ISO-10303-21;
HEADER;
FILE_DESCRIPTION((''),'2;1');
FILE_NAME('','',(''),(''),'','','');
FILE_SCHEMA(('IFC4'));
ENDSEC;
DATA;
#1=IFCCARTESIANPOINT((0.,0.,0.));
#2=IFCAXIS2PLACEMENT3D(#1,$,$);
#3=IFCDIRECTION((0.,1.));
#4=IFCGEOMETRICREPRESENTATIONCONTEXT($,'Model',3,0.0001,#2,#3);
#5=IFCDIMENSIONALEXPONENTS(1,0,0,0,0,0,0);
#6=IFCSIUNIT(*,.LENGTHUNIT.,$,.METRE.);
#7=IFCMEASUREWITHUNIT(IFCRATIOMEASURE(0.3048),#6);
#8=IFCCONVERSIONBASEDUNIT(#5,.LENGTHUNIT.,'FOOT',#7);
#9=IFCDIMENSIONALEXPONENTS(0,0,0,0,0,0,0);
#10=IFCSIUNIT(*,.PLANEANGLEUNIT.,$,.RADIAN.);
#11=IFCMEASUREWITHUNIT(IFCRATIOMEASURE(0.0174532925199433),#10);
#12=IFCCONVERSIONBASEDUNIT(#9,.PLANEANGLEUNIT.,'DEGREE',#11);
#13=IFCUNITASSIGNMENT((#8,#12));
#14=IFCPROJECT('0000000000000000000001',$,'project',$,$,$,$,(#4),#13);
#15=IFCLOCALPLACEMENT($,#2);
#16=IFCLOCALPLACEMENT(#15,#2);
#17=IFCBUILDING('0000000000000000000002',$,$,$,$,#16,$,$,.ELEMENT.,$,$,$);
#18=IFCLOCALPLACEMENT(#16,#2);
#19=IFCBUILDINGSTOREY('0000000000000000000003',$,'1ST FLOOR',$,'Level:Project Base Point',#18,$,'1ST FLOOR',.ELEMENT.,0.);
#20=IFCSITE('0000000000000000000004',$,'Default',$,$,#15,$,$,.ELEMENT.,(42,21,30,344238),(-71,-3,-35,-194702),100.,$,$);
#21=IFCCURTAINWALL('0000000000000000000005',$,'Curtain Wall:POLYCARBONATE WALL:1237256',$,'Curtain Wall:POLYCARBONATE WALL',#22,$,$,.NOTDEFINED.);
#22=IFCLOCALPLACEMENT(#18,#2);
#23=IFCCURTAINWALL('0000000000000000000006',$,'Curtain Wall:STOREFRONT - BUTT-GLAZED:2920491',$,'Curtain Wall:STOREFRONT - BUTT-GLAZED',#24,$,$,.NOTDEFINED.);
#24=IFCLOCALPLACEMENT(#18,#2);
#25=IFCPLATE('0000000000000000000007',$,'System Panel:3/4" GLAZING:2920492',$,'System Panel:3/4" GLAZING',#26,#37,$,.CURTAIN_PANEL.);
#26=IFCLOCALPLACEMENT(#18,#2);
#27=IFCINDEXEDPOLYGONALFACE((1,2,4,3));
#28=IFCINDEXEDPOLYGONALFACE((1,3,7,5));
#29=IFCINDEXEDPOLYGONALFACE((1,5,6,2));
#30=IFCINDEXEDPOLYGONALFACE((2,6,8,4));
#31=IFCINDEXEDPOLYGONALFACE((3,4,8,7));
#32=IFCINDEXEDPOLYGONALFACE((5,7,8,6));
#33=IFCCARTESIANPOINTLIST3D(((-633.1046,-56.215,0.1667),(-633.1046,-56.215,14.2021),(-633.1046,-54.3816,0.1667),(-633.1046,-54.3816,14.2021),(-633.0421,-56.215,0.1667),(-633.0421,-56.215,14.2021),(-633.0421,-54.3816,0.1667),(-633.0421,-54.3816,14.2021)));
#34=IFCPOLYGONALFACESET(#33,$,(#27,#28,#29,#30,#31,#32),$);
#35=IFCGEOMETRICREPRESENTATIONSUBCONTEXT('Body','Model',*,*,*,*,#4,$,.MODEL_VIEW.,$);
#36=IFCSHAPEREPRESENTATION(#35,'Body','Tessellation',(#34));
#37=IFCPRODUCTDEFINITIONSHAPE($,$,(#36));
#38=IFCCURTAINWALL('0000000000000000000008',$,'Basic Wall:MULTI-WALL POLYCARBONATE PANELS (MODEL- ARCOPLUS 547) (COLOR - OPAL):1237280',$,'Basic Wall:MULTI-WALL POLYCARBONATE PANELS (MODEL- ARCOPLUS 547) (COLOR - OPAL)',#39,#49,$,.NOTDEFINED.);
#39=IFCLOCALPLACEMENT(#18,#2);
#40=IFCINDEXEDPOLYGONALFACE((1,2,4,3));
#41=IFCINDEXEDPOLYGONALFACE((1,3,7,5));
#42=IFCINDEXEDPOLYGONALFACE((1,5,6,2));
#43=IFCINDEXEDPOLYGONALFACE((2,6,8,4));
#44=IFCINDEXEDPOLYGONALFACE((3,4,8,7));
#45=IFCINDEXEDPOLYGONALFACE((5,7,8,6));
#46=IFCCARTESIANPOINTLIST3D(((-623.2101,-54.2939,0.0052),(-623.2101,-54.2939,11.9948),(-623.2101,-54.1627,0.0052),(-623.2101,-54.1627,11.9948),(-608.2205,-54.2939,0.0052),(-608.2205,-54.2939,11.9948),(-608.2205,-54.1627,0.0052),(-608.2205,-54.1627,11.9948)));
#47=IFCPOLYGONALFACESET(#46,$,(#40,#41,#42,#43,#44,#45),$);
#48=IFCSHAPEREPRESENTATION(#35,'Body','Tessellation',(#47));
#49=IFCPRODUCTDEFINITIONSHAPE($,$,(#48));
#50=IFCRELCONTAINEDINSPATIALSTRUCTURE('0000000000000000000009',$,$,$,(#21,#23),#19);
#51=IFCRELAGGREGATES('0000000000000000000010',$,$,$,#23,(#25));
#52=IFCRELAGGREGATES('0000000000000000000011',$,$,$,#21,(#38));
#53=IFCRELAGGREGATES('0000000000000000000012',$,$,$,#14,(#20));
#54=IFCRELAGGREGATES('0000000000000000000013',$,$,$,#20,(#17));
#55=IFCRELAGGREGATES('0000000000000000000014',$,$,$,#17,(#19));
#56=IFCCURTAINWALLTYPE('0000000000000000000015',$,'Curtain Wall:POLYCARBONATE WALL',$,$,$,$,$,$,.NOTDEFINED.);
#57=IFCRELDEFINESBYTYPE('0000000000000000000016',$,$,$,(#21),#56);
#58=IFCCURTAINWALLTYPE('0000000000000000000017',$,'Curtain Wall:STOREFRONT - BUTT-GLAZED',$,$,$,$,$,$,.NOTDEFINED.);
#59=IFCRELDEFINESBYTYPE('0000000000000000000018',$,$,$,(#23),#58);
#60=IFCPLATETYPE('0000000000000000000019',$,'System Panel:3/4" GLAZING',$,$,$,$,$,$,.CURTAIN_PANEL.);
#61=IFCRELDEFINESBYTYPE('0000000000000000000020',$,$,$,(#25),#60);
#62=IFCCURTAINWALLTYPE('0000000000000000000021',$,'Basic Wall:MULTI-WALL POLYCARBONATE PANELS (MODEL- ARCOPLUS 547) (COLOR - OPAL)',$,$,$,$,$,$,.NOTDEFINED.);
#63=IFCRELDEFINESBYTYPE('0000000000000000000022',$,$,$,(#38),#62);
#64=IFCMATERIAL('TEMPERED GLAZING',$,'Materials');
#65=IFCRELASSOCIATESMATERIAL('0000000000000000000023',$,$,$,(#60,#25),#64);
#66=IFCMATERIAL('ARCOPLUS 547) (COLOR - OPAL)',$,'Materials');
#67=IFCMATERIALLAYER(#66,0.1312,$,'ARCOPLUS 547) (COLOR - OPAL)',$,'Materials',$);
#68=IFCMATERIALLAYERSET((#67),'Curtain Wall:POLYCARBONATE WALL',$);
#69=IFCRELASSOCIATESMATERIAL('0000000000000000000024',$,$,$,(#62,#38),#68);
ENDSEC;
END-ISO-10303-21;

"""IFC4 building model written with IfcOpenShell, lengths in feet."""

from ifc_helpers import new_model, entity, si_unit, converted_unit, direction, frame, frame_2d, origin, origin_2d_with_axis, place, context, subcontext, project, spatial, rectangle, extrude, source, transform, mapped, material, layer, layer_set, layer_usage, type_object, type_shapes, element, aggregate, save


model = new_model("IFC4")

# Units and contexts
model_context = context("Model", 3, precision=0.0001, world=origin(), true_north=direction((0.0, 1.0)))
body_context = subcontext(model_context, "Body", "Model", "MODEL_VIEW")
ifc_project = project(units=[converted_unit("LENGTHUNIT", "FOOT", entity("IfcRatioMeasure", 0.3048), si_unit("LENGTHUNIT", "METRE"), dimensions=[1, 0, 0, 0, 0, 0, 0]), converted_unit("PLANEANGLEUNIT", "DEGREE", entity("IfcRatioMeasure", 0.0174532925199433), si_unit("PLANEANGLEUNIT", "RADIAN"), dimensions=[0, 0, 0, 0, 0, 0, 0])], contexts=[model_context])

# Site, building, storey
site_placement = place(None, origin())
site = spatial("IfcSite", under=ifc_project, at=site_placement, Name="Default", CompositionType="ELEMENT", RefLatitude=(42, 21, 30, 344238), RefLongitude=(-71, -3, -35, -194702), RefElevation=100.0)
building_placement = place(site_placement, origin())
building = spatial("IfcBuilding", under=site, at=building_placement, CompositionType="ELEMENT")
storey_placement = place(building_placement, origin())
storey = spatial("IfcBuildingStorey", under=building, at=storey_placement, Name="1ST FLOOR", ObjectType="Level:Project Base Point", LongName="1ST FLOOR", CompositionType="ELEMENT", Elevation=0.0)

# Curtain wall
curtain_wall_type_1 = type_object("IfcCurtainWallType", Name="Curtain Wall:POLYCARBONATE WALL", PredefinedType="NOTDEFINED")
curtain_wall_1_placement = place(storey_placement, origin())
curtain_wall_1 = element("IfcCurtainWall", 1, at=curtain_wall_1_placement, inside=storey, type_object=curtain_wall_type_1, Name="Curtain Wall:POLYCARBONATE WALL:1237256", ObjectType="Curtain Wall:POLYCARBONATE WALL", PredefinedType="NOTDEFINED")

# Curtain wall
curtain_wall_type_2 = type_object("IfcCurtainWallType", Name="Curtain Wall:STOREFRONT - BUTT-GLAZED", PredefinedType="NOTDEFINED")
curtain_wall_2_placement = place(storey_placement, origin())
curtain_wall_2 = element("IfcCurtainWall", 2, at=curtain_wall_2_placement, inside=storey, type_object=curtain_wall_type_2, Name="Curtain Wall:STOREFRONT - BUTT-GLAZED:2920491", ObjectType="Curtain Wall:STOREFRONT - BUTT-GLAZED", PredefinedType="NOTDEFINED")

# Plate
ifc_material_1 = material(Name="TEMPERED GLAZING", Category="Materials")
plate_type_1 = type_object("IfcPlateType", Name="System Panel:3/4\" GLAZING", PredefinedType="CURTAIN_PANEL", material=ifc_material_1)
shared_shape_1 = source(origin(), body_context, "Body", "SweptSolid", [
    extrude(rectangle(XDim=0.0625, YDim=1.8333, at=origin_2d_with_axis()), frame((0.0, 0.0, 0.0), z_axis=(0.0, 0.0, 1.0), x_axis=(0.0, 1.0, 0.0)), (0.0, 0.0, 1.0), 14.0355),
])
type_shapes(plate_type_1, [shared_shape_1])
plate_1_placement = place(curtain_wall_2_placement, frame((-633.0734, -55.2983, 0.1667), z_axis=(0.0, 0.0, 1.0), x_axis=(0.0, 1.0, 0.0)))
plate_1 = element("IfcPlate", 3, at=plate_1_placement, type_object=plate_type_1, material=ifc_material_1, Name="System Panel:3/4\" GLAZING:2920492", ObjectType="System Panel:3/4\" GLAZING", PredefinedType="CURTAIN_PANEL", context=body_context, shape_type="MappedRepresentation", body=[
    mapped(shared_shape_1, transform((0.0, 0.0, 0.0), scale=1.0)),
])
aggregate(curtain_wall_2, [plate_1])

# Curtain wall
ifc_material_2 = material(Name="ARCOPLUS 547) (COLOR - OPAL)", Category="Materials")
ifc_layer = layer(ifc_material_2, 0.1312, Name="ARCOPLUS 547) (COLOR - OPAL)", Category="Materials")
ifc_layer_set = layer_set([ifc_layer], Name="Curtain Wall:POLYCARBONATE WALL")
ifc_layer_usage = layer_usage(ifc_layer_set, "AXIS2", "NEGATIVE", 0.0656)
curtain_wall_type_3 = type_object("IfcCurtainWallType", Name="Basic Wall:MULTI-WALL POLYCARBONATE PANELS (MODEL- ARCOPLUS 547) (COLOR - OPAL)", PredefinedType="NOTDEFINED", material=ifc_layer_set)
curtain_wall_3_placement = place(storey_placement, frame((-623.2101, -54.2283, 0.0052)))
curtain_wall_3 = element("IfcCurtainWall", 4, at=curtain_wall_3_placement, type_object=curtain_wall_type_3, material=ifc_layer_usage, Name="Basic Wall:MULTI-WALL POLYCARBONATE PANELS (MODEL- ARCOPLUS 547) (COLOR - OPAL):1237280", ObjectType="Basic Wall:MULTI-WALL POLYCARBONATE PANELS (MODEL- ARCOPLUS 547) (COLOR - OPAL)", PredefinedType="NOTDEFINED", context=body_context, shape_type="SweptSolid", body=[
    extrude(rectangle(XDim=14.9896, YDim=0.1312, at=frame_2d((7.4948, 0.0), x_axis=(-1.0, 0.0))), origin(), (0.0, 0.0, 1.0), 11.9896),
])
aggregate(curtain_wall_1, [curtain_wall_3])

save(model, "model.ifc")
